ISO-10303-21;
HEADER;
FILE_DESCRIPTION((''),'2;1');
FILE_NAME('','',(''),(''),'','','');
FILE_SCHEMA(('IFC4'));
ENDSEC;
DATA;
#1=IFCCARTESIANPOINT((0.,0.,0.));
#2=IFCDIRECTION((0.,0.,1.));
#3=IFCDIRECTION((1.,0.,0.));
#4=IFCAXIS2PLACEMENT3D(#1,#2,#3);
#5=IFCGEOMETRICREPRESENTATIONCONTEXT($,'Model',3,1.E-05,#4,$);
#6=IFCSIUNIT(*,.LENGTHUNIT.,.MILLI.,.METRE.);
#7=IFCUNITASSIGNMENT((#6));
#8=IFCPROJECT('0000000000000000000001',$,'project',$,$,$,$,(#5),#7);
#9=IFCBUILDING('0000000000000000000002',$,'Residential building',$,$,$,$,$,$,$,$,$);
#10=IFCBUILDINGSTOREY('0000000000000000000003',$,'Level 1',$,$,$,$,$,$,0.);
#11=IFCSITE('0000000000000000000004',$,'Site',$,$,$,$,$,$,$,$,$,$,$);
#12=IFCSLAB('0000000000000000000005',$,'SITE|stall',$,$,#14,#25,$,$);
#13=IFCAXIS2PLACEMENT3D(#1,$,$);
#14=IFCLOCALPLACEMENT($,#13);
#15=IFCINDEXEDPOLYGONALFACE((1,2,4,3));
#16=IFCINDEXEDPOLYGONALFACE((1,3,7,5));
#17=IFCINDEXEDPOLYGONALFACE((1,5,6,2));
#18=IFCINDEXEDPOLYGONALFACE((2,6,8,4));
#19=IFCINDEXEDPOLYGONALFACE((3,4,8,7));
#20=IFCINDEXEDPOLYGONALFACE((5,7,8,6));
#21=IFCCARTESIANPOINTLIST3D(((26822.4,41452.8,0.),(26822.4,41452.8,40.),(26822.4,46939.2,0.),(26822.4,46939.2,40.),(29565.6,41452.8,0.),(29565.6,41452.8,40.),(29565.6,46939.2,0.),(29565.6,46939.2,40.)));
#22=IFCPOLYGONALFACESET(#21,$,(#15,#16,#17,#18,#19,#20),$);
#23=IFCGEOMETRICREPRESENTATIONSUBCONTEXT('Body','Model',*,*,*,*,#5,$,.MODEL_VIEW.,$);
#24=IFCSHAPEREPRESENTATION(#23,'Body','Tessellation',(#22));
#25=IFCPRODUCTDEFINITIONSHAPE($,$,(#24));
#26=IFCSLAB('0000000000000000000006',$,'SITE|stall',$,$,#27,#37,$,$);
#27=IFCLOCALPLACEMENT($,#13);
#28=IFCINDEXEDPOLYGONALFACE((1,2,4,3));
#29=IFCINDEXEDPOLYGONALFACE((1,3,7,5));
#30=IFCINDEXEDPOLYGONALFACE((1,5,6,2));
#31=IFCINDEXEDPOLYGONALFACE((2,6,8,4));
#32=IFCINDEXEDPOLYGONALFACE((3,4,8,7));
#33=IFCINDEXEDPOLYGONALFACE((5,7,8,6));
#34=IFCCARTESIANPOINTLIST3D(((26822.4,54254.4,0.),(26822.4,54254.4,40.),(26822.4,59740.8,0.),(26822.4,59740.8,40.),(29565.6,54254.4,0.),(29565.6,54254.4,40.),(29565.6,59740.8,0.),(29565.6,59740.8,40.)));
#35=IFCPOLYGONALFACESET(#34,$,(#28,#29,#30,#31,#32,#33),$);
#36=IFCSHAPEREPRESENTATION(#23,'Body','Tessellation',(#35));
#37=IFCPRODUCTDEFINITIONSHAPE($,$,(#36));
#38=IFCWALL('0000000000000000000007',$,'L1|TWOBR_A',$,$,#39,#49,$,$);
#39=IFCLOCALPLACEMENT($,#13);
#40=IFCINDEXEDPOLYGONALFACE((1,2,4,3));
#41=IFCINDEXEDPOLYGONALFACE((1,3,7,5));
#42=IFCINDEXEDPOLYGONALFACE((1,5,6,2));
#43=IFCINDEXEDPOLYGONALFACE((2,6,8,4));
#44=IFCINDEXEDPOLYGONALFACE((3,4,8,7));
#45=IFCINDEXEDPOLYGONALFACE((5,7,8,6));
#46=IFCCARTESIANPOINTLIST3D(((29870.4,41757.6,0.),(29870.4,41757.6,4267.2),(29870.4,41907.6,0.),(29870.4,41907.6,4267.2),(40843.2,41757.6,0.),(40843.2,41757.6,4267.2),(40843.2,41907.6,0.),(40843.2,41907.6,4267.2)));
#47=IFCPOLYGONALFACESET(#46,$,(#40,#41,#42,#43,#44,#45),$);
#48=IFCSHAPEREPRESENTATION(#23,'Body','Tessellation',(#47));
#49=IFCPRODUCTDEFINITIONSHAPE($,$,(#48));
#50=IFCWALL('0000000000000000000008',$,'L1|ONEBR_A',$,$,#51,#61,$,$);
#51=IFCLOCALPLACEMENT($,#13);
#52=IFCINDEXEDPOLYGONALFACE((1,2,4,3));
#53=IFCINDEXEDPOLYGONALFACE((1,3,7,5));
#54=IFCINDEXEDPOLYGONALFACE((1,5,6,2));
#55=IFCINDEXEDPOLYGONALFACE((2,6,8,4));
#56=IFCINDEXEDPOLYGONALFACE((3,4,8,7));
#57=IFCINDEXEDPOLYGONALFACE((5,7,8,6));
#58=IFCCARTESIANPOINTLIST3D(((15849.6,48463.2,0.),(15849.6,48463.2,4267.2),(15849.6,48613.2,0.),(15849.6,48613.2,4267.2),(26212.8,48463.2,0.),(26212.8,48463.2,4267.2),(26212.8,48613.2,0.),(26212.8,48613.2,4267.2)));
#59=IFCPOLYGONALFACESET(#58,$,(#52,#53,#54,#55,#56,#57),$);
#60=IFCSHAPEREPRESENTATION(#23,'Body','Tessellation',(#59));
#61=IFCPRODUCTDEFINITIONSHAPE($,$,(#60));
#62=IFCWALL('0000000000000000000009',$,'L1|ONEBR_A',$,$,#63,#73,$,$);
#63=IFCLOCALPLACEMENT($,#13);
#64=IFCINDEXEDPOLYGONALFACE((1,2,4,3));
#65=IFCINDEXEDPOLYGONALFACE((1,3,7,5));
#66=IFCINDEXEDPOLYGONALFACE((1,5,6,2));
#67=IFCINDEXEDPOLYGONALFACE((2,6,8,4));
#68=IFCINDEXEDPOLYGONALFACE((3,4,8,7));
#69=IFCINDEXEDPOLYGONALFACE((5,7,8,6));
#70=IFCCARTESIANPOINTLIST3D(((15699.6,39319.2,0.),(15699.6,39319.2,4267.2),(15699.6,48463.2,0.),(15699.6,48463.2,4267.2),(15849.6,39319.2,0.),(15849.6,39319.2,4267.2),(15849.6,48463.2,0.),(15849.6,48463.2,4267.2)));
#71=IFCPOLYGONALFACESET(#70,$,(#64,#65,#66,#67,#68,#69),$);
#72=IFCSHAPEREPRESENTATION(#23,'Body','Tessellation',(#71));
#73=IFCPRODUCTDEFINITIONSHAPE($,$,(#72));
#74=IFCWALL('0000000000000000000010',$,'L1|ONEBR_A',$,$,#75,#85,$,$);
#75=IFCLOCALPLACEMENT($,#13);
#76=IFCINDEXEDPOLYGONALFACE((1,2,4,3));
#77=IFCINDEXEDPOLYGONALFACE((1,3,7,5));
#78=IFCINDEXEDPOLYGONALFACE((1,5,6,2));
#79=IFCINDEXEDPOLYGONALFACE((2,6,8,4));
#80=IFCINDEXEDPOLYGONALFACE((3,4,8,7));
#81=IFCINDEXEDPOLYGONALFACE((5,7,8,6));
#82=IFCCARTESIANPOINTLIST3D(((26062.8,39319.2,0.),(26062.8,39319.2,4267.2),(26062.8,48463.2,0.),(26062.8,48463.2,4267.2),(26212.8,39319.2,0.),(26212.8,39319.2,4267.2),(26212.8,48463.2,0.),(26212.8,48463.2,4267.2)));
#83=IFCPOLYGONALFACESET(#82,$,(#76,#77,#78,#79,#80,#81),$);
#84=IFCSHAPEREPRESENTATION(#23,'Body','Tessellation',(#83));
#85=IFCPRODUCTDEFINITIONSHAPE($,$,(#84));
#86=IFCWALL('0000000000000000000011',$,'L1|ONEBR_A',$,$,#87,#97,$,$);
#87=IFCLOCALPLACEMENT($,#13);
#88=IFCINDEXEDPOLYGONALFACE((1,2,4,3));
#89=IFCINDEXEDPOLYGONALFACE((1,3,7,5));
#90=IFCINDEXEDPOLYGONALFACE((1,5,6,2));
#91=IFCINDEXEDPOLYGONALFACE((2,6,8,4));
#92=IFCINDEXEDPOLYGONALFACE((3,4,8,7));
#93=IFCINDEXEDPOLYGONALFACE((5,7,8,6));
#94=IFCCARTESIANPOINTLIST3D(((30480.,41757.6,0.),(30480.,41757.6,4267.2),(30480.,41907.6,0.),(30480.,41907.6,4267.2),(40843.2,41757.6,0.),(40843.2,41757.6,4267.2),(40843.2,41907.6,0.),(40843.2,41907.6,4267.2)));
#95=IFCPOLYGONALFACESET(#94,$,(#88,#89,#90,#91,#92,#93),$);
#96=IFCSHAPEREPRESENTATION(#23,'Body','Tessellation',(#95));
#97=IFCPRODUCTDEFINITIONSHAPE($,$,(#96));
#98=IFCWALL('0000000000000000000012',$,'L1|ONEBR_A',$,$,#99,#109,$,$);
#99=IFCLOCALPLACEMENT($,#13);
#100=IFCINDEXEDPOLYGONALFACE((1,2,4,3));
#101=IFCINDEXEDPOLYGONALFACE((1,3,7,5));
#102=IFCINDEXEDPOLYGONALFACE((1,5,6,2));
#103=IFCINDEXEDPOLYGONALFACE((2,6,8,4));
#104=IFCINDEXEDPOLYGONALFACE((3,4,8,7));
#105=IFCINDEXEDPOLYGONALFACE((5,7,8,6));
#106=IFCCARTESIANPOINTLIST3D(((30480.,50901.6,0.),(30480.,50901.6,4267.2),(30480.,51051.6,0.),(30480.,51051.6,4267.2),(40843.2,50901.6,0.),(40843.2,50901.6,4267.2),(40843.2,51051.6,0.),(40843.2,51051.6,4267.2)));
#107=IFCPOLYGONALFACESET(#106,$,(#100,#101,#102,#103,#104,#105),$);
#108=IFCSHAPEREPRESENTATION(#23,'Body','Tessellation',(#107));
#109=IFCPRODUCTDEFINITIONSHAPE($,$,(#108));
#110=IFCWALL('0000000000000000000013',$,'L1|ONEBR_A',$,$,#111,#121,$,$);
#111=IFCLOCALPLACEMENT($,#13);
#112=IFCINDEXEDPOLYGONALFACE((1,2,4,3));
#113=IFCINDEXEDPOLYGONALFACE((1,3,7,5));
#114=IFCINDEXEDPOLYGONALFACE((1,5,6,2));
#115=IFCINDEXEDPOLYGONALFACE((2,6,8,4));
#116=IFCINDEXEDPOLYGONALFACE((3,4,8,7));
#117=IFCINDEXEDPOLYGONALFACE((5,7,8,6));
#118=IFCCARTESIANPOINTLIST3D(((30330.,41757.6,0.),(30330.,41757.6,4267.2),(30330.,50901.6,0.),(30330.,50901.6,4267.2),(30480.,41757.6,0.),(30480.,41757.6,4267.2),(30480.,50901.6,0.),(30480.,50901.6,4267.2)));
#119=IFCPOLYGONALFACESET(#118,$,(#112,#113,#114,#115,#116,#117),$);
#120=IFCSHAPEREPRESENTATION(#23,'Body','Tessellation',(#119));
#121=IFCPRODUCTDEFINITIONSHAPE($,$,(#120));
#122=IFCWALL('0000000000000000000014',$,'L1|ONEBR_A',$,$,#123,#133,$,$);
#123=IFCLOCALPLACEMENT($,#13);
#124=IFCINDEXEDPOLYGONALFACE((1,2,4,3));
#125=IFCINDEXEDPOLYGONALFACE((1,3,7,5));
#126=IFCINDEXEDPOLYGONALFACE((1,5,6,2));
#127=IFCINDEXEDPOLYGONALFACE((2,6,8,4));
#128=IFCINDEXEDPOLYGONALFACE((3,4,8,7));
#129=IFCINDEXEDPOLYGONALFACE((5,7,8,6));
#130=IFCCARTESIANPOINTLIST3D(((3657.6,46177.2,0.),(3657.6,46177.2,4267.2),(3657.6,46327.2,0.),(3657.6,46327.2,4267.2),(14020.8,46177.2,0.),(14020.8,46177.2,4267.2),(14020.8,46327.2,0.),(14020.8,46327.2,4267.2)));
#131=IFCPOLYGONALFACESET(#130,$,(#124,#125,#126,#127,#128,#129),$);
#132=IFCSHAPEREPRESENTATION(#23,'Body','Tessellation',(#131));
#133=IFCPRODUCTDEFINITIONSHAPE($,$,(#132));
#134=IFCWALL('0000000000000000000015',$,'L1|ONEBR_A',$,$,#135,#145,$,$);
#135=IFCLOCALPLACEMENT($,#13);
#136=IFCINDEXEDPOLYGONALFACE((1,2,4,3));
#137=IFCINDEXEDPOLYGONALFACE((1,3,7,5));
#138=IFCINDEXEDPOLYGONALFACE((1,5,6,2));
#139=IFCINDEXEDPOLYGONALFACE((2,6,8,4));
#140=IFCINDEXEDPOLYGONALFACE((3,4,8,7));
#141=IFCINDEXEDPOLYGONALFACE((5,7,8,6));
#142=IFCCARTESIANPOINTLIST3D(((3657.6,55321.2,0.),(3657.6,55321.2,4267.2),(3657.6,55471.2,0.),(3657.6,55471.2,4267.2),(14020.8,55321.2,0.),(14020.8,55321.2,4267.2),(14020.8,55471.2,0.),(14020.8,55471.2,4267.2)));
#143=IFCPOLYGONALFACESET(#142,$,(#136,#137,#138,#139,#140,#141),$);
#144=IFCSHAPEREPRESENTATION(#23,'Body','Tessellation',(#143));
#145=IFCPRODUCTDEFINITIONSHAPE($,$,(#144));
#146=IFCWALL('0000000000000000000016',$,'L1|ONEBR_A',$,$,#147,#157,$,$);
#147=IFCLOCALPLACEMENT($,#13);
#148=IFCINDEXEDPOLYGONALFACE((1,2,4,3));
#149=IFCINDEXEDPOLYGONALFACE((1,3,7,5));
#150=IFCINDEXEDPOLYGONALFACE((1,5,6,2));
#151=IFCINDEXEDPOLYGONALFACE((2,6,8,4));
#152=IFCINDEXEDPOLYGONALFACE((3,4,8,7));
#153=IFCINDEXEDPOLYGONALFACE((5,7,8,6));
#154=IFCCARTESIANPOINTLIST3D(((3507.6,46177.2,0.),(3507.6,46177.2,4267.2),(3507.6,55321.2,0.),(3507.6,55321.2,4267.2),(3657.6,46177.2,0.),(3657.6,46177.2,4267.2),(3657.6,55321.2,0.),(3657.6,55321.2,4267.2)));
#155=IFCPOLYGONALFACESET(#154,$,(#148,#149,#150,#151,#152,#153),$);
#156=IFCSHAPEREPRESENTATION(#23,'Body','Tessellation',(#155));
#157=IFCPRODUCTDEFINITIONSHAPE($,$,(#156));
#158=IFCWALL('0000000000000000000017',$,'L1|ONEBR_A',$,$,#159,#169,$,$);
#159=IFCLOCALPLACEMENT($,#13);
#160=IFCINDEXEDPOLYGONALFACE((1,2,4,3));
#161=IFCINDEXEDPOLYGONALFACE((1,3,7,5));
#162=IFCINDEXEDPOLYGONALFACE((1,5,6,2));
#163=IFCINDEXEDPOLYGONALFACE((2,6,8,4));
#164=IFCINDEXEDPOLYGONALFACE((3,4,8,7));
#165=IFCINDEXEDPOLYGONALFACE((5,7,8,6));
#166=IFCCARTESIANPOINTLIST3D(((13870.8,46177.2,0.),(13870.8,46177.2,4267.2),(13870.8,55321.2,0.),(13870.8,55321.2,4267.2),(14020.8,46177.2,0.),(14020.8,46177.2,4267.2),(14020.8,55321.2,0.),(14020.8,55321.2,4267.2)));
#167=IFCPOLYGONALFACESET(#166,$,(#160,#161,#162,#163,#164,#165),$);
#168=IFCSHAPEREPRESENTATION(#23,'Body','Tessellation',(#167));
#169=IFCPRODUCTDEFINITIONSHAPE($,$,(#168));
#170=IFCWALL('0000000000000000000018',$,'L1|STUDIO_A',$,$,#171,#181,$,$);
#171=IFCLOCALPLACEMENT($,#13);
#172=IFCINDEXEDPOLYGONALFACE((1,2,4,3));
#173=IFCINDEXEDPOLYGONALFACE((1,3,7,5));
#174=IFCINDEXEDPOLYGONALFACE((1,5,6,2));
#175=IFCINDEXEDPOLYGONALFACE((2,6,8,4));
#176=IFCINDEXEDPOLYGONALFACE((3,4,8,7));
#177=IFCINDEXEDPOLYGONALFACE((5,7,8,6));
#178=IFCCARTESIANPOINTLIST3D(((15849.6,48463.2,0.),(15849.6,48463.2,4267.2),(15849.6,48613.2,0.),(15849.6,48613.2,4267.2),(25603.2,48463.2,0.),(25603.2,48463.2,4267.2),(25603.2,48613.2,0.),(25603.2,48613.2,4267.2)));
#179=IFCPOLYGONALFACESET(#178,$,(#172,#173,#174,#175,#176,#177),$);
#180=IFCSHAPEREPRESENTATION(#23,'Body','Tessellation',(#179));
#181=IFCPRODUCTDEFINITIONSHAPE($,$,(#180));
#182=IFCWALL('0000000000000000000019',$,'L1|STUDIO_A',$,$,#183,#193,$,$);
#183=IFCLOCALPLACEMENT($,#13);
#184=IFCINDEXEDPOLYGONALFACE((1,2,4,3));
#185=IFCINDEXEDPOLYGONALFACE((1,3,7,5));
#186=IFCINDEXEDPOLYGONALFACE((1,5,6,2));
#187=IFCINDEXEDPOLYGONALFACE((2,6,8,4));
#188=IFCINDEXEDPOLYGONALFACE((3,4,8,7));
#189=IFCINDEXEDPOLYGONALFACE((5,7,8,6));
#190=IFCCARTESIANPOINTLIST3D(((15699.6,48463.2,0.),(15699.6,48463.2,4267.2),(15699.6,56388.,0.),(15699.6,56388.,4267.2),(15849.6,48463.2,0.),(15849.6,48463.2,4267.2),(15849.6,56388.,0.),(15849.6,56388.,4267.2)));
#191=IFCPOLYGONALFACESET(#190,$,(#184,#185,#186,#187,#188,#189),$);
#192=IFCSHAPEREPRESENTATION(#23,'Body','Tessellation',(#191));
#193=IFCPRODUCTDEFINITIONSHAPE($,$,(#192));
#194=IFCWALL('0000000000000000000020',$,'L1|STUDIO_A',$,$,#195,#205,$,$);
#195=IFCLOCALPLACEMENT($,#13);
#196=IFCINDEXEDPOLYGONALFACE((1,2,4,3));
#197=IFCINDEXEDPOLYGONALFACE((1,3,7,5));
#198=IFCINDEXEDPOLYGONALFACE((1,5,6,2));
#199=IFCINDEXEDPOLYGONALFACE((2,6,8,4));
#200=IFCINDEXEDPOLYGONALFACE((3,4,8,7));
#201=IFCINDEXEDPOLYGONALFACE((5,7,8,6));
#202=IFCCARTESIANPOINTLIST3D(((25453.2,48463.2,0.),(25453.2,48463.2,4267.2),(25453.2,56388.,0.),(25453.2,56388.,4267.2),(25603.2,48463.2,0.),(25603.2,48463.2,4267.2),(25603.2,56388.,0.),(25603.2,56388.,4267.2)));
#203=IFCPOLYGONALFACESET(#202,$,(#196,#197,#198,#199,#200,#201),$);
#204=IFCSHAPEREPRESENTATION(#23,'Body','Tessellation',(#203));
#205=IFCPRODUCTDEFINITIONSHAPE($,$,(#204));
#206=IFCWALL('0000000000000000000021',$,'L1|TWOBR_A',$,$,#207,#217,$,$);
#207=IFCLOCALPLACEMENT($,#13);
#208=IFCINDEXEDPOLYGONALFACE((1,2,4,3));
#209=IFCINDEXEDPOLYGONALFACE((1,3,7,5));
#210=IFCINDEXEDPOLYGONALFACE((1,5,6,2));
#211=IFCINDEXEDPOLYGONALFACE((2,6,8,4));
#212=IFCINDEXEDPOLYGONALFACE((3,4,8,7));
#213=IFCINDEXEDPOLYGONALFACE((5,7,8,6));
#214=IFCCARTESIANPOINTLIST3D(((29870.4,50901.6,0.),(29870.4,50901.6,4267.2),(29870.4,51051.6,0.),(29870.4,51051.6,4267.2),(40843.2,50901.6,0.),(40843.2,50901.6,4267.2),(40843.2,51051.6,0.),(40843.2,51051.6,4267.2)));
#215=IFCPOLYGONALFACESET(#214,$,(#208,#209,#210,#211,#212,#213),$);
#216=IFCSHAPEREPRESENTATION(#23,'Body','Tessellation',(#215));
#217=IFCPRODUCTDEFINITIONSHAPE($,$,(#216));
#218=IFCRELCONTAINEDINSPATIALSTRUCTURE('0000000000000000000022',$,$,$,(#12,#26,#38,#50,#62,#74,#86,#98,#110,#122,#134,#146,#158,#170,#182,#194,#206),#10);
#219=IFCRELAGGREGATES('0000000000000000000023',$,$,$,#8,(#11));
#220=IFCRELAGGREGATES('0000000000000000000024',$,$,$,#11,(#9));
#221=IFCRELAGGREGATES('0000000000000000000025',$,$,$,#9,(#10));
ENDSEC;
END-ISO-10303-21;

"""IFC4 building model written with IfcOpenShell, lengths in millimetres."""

from ifc_helpers import new_model, si_unit, frame, origin_with_axes, place, context, subcontext, project, spatial, indexed_curve, outline, extrude, element, save


model = new_model("IFC4")

# Units and contexts
model_context = context("Model", 3, precision=1e-05, world=origin_with_axes())
body_context = subcontext(model_context, "Body", "Model", "MODEL_VIEW")
ifc_project = project(units=[si_unit("LENGTHUNIT", "METRE", prefix="MILLI")], contexts=[model_context])

# Site, building, storey
site = spatial("IfcSite", under=ifc_project, Name="Site")
building = spatial("IfcBuilding", under=site, Name="Residential building")
storey = spatial("IfcBuildingStorey", under=building, Name="Level 1", Elevation=0.0)

# Slabs
for number, where, z_axis, x_axis, name in (
    (1, (26822.4, 41452.8, 0.0), (0.0, 0.0, 1.0), (1.0, 0.0, 0.0), "SITE|stall"),
    (2, (26822.4, 54254.4, 0.0), (0.0, 0.0, 1.0), (1.0, 0.0, 0.0), "SITE|stall"),
):
    element("IfcSlab", number, at=place(None, frame(where, z_axis=z_axis, x_axis=x_axis)), inside=storey, Name=name, context=body_context, shape_type="SweptSolid", body=[
        extrude(outline(indexed_curve([(0.0, 0.0), (2743.2, 0.0), (2743.2, 5486.4), (0.0, 5486.4), (0.0, 0.0)])), None, (0.0, 0.0, 1.0), 40.0),
    ])

# Walls
wall_1_placement = place(None, frame((29870.4, 41757.6, 0.0), z_axis=(0.0, 0.0, 1.0), x_axis=(1.0, 0.0, 0.0)))
element("IfcWall", 3, at=wall_1_placement, inside=storey, Name="L1|TWOBR_A", context=body_context, shape_type="SweptSolid", body=[
    extrude(outline(indexed_curve([(0.0, 0.0), (0.0, 150.0), (10972.8, 150.0), (10972.8, 0.0), (0.0, 0.0)], self_intersect=False)), origin_with_axes(), (0.0, 0.0, 1.0), 4267.2),
])
wall_2_placement = place(None, frame((15849.6, 48463.2, 0.0), z_axis=(0.0, 0.0, 1.0), x_axis=(1.0, 0.0, 0.0)))
element("IfcWall", 4, at=wall_2_placement, inside=storey, Name="L1|ONEBR_A", context=body_context, shape_type="SweptSolid", body=[
    extrude(outline(indexed_curve([(0.0, 0.0), (0.0, 150.0), (10363.2, 150.0), (10363.2, 0.0), (0.0, 0.0)], self_intersect=False)), origin_with_axes(), (0.0, 0.0, 1.0), 4267.2),
])
for number, where, z_axis, x_axis, name in (
    (5, (15849.6, 39319.2, 0.0), (0.0, 0.0, 1.0), (0.0, 1.0, 0.0), "L1|ONEBR_A"),
    (6, (26212.8, 39319.2, 0.0), (0.0, 0.0, 1.0), (0.0, 1.0, 0.0), "L1|ONEBR_A"),
):
    element("IfcWall", number, at=place(None, frame(where, z_axis=z_axis, x_axis=x_axis)), inside=storey, Name=name, context=body_context, shape_type="SweptSolid", body=[
        extrude(outline(indexed_curve([(0.0, 0.0), (0.0, 150.0), (9144.0, 150.0), (9144.0, 0.0), (0.0, 0.0)], self_intersect=False)), origin_with_axes(), (0.0, 0.0, 1.0), 4267.2),
    ])
for number, where, z_axis, x_axis, name in (
    (7, (30480.0, 41757.6, 0.0), (0.0, 0.0, 1.0), (1.0, 0.0, 0.0), "L1|ONEBR_A"),
    (8, (30480.0, 50901.6, 0.0), (0.0, 0.0, 1.0), (1.0, 0.0, 0.0), "L1|ONEBR_A"),
):
    element("IfcWall", number, at=place(None, frame(where, z_axis=z_axis, x_axis=x_axis)), inside=storey, Name=name, context=body_context, shape_type="SweptSolid", body=[
        extrude(outline(indexed_curve([(0.0, 0.0), (0.0, 150.0), (10363.2, 150.0), (10363.2, 0.0), (0.0, 0.0)], self_intersect=False)), origin_with_axes(), (0.0, 0.0, 1.0), 4267.2),
    ])
wall_3_placement = place(None, frame((30480.0, 41757.6, 0.0), z_axis=(0.0, 0.0, 1.0), x_axis=(0.0, 1.0, 0.0)))
element("IfcWall", 9, at=wall_3_placement, inside=storey, Name="L1|ONEBR_A", context=body_context, shape_type="SweptSolid", body=[
    extrude(outline(indexed_curve([(0.0, 0.0), (0.0, 150.0), (9144.0, 150.0), (9144.0, 0.0), (0.0, 0.0)], self_intersect=False)), origin_with_axes(), (0.0, 0.0, 1.0), 4267.2),
])
for number, where, z_axis, x_axis, name in (
    (10, (3657.6, 46177.2, 0.0), (0.0, 0.0, 1.0), (1.0, 0.0, 0.0), "L1|ONEBR_A"),
    (11, (3657.6, 55321.2, 0.0), (0.0, 0.0, 1.0), (1.0, 0.0, 0.0), "L1|ONEBR_A"),
):
    element("IfcWall", number, at=place(None, frame(where, z_axis=z_axis, x_axis=x_axis)), inside=storey, Name=name, context=body_context, shape_type="SweptSolid", body=[
        extrude(outline(indexed_curve([(0.0, 0.0), (0.0, 150.0), (10363.2, 150.0), (10363.2, 0.0), (0.0, 0.0)], self_intersect=False)), origin_with_axes(), (0.0, 0.0, 1.0), 4267.2),
    ])
for number, where, z_axis, x_axis, name in (
    (12, (3657.6, 46177.2, 0.0), (0.0, 0.0, 1.0), (0.0, 1.0, 0.0), "L1|ONEBR_A"),
    (13, (14020.8, 46177.2, 0.0), (0.0, 0.0, 1.0), (0.0, 1.0, 0.0), "L1|ONEBR_A"),
):
    element("IfcWall", number, at=place(None, frame(where, z_axis=z_axis, x_axis=x_axis)), inside=storey, Name=name, context=body_context, shape_type="SweptSolid", body=[
        extrude(outline(indexed_curve([(0.0, 0.0), (0.0, 150.0), (9144.0, 150.0), (9144.0, 0.0), (0.0, 0.0)], self_intersect=False)), origin_with_axes(), (0.0, 0.0, 1.0), 4267.2),
    ])
wall_4_placement = place(None, frame((15849.6, 48463.2, 0.0), z_axis=(0.0, 0.0, 1.0), x_axis=(1.0, 0.0, 0.0)))
element("IfcWall", 14, at=wall_4_placement, inside=storey, Name="L1|STUDIO_A", context=body_context, shape_type="SweptSolid", body=[
    extrude(outline(indexed_curve([(0.0, 0.0), (0.0, 150.0), (9753.6, 150.0), (9753.6, 0.0), (0.0, 0.0)], self_intersect=False)), origin_with_axes(), (0.0, 0.0, 1.0), 4267.2),
])
for number, where, z_axis, x_axis, name in (
    (15, (15849.6, 48463.2, 0.0), (0.0, 0.0, 1.0), (0.0, 1.0, 0.0), "L1|STUDIO_A"),
    (16, (25603.2, 48463.2, 0.0), (0.0, 0.0, 1.0), (0.0, 1.0, 0.0), "L1|STUDIO_A"),
):
    element("IfcWall", number, at=place(None, frame(where, z_axis=z_axis, x_axis=x_axis)), inside=storey, Name=name, context=body_context, shape_type="SweptSolid", body=[
        extrude(outline(indexed_curve([(0.0, 0.0), (0.0, 150.0), (7924.8, 150.0), (7924.8, 0.0), (0.0, 0.0)], self_intersect=False)), origin_with_axes(), (0.0, 0.0, 1.0), 4267.2),
    ])
wall_5_placement = place(None, frame((29870.4, 50901.6, 0.0), z_axis=(0.0, 0.0, 1.0), x_axis=(1.0, 0.0, 0.0)))
element("IfcWall", 17, at=wall_5_placement, inside=storey, Name="L1|TWOBR_A", context=body_context, shape_type="SweptSolid", body=[
    extrude(outline(indexed_curve([(0.0, 0.0), (0.0, 150.0), (10972.8, 150.0), (10972.8, 0.0), (0.0, 0.0)], self_intersect=False)), origin_with_axes(), (0.0, 0.0, 1.0), 4267.2),
])

save(model, "model.ifc")
